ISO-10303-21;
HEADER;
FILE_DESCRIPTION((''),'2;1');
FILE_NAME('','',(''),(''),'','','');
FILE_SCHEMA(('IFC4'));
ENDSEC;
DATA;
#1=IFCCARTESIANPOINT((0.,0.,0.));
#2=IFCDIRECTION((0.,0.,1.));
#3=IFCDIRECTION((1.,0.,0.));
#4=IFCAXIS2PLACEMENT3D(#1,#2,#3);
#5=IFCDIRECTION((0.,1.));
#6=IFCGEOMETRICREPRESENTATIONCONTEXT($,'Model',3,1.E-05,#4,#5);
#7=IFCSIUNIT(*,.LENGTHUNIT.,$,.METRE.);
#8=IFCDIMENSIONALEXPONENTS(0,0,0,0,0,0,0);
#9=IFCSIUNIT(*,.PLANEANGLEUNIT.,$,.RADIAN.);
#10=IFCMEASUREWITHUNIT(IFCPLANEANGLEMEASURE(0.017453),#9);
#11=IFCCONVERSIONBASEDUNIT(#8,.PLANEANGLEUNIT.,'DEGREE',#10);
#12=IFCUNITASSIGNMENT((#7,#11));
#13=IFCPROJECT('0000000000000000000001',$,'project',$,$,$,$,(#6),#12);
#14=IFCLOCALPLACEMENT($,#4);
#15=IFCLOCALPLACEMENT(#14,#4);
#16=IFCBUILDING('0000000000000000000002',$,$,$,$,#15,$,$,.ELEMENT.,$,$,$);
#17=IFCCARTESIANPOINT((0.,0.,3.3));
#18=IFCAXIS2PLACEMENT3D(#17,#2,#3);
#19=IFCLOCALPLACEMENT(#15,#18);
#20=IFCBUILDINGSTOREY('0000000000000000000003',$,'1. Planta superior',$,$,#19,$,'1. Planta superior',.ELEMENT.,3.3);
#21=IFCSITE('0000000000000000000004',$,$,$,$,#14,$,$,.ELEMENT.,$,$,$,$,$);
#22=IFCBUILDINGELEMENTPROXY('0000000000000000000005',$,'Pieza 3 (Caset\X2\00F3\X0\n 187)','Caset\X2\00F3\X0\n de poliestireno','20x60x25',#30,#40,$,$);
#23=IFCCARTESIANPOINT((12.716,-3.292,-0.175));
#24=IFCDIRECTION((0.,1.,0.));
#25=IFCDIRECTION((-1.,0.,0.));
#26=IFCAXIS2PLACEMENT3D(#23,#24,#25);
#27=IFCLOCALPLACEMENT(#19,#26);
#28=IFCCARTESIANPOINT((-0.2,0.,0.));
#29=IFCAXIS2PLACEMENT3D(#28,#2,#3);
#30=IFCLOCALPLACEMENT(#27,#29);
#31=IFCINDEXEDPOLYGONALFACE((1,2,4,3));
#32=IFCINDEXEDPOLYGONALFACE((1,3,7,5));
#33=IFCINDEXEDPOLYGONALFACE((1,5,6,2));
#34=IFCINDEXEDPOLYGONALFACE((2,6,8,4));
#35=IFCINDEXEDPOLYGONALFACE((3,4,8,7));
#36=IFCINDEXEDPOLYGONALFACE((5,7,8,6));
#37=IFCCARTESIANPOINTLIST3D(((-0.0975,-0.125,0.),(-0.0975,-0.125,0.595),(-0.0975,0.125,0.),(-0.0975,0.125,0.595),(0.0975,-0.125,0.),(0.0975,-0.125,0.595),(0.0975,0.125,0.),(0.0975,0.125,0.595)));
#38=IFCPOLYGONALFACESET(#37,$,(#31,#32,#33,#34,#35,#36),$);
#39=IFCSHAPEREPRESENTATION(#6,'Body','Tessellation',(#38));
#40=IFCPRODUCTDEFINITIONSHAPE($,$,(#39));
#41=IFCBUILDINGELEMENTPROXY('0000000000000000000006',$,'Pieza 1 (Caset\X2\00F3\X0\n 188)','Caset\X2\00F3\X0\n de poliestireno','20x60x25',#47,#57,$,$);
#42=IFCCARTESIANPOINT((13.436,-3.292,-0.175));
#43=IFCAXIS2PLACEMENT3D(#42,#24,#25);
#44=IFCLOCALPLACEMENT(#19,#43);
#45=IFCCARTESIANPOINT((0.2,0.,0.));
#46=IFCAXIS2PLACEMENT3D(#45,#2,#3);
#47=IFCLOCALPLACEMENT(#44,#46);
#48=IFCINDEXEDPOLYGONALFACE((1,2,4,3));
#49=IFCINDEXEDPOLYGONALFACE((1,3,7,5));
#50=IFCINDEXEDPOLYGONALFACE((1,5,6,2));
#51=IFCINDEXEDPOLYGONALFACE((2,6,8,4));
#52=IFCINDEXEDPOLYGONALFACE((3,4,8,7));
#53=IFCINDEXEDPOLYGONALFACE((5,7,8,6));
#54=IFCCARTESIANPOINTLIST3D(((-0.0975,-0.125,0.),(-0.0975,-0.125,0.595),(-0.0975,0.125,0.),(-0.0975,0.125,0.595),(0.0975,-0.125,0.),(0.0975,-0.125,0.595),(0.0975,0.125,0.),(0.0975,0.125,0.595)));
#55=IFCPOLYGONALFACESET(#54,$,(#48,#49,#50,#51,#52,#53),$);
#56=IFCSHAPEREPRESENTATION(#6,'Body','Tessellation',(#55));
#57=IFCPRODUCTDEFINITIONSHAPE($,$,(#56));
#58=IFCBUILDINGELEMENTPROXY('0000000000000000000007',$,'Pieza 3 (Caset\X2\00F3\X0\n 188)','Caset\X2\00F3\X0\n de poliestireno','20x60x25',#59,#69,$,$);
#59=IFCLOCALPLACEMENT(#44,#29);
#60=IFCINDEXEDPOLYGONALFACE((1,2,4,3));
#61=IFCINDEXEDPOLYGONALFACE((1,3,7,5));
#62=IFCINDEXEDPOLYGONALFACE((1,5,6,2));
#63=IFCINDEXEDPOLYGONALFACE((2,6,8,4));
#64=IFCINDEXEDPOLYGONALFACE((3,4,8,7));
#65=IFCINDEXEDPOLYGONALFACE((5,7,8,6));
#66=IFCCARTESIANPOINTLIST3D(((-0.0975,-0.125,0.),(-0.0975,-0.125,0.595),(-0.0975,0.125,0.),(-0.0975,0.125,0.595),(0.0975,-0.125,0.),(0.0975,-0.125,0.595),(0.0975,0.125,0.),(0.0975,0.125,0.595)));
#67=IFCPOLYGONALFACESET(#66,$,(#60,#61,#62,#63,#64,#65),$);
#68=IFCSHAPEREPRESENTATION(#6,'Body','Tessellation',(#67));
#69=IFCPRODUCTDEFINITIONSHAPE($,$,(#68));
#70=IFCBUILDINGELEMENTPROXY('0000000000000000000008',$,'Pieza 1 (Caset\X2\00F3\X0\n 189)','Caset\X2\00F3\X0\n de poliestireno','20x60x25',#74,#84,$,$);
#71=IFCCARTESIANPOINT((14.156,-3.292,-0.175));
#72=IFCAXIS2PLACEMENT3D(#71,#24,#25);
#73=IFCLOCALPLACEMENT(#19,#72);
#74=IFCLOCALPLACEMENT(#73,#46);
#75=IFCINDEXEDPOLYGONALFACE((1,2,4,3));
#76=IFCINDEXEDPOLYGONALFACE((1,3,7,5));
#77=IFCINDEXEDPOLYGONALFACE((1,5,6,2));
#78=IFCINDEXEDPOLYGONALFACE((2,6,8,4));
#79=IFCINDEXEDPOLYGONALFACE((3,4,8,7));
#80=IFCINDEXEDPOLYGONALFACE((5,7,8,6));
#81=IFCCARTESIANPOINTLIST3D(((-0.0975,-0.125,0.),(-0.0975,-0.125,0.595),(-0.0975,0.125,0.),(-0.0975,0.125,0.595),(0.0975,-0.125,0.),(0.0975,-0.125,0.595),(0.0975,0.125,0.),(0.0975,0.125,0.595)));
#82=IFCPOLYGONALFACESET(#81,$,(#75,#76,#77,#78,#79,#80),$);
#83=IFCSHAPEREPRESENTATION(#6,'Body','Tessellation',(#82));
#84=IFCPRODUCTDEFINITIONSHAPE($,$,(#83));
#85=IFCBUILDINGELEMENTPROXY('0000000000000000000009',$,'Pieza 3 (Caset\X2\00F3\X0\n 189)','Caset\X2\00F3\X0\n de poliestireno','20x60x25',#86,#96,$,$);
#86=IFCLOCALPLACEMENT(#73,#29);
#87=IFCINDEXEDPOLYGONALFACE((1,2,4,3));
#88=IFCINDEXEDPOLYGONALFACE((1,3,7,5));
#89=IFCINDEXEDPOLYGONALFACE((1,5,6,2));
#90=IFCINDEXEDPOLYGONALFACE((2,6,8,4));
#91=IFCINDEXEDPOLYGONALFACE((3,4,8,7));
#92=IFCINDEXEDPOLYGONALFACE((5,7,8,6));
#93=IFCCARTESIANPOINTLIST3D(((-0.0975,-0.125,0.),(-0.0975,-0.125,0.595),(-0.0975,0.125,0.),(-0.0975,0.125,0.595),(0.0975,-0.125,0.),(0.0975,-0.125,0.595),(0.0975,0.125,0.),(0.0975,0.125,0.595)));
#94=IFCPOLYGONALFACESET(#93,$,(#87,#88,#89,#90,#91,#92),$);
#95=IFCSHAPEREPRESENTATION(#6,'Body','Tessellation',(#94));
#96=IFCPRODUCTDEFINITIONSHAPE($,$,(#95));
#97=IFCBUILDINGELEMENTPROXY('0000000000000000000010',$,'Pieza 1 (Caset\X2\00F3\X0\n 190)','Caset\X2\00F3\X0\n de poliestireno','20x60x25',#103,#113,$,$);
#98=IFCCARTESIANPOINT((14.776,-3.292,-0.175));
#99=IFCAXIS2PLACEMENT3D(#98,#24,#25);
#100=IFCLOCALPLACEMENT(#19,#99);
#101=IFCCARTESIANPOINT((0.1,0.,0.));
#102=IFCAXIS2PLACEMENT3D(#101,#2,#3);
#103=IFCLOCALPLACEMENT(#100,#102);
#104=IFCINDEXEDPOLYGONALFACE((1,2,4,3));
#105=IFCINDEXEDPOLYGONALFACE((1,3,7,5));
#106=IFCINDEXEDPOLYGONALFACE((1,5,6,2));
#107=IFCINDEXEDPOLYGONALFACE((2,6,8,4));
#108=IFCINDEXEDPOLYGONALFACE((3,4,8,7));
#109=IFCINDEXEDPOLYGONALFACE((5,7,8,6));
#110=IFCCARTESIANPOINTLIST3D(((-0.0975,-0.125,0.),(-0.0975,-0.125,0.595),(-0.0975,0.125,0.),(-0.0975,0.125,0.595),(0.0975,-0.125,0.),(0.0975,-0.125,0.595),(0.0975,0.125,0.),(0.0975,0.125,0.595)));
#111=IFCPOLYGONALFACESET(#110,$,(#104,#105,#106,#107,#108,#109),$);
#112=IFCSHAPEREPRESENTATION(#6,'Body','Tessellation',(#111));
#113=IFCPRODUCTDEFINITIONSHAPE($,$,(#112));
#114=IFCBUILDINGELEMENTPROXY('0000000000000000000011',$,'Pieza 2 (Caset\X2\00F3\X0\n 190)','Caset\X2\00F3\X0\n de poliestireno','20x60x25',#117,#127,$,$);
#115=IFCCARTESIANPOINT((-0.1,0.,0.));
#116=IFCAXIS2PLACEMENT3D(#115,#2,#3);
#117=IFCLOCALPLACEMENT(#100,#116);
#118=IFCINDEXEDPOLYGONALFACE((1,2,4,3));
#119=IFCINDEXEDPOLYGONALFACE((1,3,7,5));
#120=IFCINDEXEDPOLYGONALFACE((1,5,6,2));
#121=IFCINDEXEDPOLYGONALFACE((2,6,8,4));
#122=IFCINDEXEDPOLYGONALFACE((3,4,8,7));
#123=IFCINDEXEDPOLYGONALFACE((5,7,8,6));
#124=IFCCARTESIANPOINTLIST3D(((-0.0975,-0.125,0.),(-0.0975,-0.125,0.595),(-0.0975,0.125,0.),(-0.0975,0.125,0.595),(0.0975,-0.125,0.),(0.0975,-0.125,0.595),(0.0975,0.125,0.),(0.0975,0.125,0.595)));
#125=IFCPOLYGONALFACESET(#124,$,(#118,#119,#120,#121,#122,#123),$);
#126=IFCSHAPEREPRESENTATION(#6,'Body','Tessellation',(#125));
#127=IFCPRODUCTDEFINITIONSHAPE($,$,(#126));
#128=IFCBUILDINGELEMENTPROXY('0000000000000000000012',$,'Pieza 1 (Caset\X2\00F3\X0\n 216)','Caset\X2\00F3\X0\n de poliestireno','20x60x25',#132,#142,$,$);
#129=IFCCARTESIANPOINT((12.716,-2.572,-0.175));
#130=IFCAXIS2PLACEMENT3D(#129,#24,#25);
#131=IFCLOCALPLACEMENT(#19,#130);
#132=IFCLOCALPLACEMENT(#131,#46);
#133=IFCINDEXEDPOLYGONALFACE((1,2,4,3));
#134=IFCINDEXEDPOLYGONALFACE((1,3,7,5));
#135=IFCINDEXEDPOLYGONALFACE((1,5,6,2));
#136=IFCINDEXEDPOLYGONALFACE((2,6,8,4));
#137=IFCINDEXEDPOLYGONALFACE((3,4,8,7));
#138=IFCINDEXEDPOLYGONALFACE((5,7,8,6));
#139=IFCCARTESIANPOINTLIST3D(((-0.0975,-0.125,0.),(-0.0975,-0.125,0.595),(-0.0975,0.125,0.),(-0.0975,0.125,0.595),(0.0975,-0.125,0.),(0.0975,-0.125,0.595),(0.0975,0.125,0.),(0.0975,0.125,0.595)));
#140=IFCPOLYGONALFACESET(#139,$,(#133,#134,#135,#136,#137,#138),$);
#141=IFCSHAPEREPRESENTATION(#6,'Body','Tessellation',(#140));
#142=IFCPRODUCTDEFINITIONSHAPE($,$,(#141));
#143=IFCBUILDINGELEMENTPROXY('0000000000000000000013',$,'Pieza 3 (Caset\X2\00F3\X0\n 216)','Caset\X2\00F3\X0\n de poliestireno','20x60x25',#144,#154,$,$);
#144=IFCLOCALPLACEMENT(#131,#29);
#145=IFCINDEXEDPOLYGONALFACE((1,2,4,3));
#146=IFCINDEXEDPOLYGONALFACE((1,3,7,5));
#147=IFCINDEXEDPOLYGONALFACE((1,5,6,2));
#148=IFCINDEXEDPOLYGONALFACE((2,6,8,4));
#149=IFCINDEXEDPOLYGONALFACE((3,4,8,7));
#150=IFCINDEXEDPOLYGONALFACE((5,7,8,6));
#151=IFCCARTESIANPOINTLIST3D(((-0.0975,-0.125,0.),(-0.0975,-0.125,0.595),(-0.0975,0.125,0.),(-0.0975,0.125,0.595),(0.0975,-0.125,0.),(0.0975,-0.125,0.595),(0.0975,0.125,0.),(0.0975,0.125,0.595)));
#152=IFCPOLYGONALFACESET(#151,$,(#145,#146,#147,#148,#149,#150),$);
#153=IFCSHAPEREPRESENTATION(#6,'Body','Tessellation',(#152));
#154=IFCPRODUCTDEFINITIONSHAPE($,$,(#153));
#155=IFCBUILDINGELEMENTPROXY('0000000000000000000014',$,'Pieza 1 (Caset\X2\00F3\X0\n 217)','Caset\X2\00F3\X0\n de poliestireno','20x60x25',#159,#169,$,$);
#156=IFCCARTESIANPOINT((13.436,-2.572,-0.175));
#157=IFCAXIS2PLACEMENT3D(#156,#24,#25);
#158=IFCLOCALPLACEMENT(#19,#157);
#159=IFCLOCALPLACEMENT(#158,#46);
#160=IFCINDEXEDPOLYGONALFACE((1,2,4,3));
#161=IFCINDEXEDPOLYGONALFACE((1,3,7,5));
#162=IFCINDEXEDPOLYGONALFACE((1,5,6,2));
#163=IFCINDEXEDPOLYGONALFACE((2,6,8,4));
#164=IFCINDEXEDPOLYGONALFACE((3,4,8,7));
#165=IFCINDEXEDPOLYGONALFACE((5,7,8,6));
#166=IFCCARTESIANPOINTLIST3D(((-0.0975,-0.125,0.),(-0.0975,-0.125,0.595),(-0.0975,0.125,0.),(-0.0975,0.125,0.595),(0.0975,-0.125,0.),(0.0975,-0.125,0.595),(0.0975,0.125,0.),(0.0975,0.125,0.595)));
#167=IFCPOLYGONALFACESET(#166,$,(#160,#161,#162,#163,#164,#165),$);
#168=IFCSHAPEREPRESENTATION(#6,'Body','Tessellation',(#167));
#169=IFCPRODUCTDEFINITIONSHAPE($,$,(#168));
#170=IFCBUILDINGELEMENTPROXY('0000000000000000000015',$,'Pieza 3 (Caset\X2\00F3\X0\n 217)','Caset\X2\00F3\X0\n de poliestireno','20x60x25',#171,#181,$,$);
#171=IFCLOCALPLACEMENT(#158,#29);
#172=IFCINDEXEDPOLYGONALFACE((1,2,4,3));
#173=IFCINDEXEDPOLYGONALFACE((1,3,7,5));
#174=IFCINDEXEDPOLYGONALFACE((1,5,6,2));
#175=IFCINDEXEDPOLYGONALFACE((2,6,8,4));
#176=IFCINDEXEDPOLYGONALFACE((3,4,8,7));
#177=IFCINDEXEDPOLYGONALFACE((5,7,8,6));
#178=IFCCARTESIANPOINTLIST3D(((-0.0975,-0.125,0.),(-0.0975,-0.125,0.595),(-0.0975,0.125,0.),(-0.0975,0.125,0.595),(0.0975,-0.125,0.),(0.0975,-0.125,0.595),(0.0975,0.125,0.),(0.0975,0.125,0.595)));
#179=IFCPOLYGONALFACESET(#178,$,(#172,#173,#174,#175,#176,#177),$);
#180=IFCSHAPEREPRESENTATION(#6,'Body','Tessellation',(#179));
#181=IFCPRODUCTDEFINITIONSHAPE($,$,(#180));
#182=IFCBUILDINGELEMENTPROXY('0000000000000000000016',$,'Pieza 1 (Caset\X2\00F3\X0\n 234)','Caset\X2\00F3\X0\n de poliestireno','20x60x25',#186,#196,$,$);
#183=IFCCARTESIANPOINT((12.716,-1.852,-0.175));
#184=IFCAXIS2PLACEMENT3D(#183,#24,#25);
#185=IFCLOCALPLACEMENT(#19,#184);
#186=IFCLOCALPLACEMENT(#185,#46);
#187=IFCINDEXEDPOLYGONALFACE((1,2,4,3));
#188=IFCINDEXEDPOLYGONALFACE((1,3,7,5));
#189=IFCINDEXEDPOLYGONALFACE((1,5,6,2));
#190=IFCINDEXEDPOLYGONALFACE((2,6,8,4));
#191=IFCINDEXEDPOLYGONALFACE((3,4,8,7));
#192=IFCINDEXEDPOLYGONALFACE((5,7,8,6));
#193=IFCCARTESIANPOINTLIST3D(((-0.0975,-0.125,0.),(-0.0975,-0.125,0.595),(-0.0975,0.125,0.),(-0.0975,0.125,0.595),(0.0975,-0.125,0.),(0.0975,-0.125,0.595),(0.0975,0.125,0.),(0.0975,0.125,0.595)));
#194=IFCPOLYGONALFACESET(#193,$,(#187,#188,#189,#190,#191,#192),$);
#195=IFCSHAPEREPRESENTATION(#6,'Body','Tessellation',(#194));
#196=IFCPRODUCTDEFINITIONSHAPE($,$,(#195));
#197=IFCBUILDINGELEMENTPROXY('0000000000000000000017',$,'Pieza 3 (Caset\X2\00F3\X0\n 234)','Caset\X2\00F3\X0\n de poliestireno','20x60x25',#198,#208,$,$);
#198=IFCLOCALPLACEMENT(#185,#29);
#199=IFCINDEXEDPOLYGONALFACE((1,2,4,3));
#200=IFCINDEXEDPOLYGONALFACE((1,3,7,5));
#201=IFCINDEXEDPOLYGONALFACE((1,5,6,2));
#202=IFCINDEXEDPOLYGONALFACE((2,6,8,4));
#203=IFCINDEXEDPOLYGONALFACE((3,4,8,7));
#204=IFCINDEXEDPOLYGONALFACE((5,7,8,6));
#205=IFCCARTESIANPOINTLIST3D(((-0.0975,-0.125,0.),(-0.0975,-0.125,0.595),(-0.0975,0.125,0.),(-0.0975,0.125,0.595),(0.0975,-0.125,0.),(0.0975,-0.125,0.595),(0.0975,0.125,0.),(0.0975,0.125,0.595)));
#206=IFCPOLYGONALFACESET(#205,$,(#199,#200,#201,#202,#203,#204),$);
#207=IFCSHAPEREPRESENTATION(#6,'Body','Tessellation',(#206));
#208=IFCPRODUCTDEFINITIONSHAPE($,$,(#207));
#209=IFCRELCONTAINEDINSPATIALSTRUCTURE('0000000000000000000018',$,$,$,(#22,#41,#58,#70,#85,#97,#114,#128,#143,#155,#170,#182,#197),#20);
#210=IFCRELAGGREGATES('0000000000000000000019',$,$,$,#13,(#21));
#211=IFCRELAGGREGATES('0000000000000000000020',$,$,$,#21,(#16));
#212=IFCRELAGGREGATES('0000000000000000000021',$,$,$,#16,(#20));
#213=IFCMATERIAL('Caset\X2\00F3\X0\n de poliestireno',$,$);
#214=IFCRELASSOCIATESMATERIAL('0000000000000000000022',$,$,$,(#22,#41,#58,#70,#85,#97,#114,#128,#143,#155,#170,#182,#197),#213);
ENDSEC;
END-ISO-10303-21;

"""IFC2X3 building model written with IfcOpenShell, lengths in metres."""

from ifc_helpers import new_model, entity, si_unit, converted_unit, direction, frame, origin_with_axes, origin_2d_with_axis, place, context, project, spatial, rectangle, extrude, source, transform, mapped, material, element, save


model = new_model("IFC2X3")

# Units and contexts
model_context = context("Model", 3, precision=1e-05, world=origin_with_axes(), true_north=direction((0.0, 1.0)))
ifc_project = project(units=[si_unit("LENGTHUNIT", "METRE"), converted_unit("PLANEANGLEUNIT", "DEGREE", entity("IfcPlaneAngleMeasure", 0.017453), si_unit("PLANEANGLEUNIT", "RADIAN"), dimensions=[0, 0, 0, 0, 0, 0, 0])], contexts=[model_context])

# Site, building, storey
site_placement = place(None, origin_with_axes())
site = spatial("IfcSite", under=ifc_project, at=site_placement, CompositionType="ELEMENT")
building_placement = place(site_placement, origin_with_axes())
building = spatial("IfcBuilding", under=site, at=building_placement, CompositionType="ELEMENT")
storey_placement = place(building_placement, frame((0.0, 0.0, 3.3), z_axis=(0.0, 0.0, 1.0), x_axis=(1.0, 0.0, 0.0)))
storey = spatial("IfcBuildingStorey", under=building, at=storey_placement, Name="1. Planta superior", LongName="1. Planta superior", CompositionType="ELEMENT", Elevation=3.3)

# Building element proxies
ifc_material = material(Name="Casetón de poliestireno")
shared_shape = source(origin_with_axes(), model_context, "Body", "SweptSolid", [
    extrude(rectangle(XDim=0.195, YDim=0.25, at=origin_2d_with_axis()), origin_with_axes(), (0.0, 0.0, 1.0), 0.595),
])
placement_1 = place(storey_placement, frame((12.716, -3.292, -0.175), z_axis=(0.0, 1.0, 0.0), x_axis=(-1.0, 0.0, 0.0)))
for number, where, z_axis, x_axis, name in (
    (1, (-0.2, 0.0, 0.0), (0.0, 0.0, 1.0), (1.0, 0.0, 0.0), "Pieza 3 (Casetón 187)"),
):
    element("IfcBuildingElementProxy", number, at=place(placement_1, frame(where, z_axis=z_axis, x_axis=x_axis)), inside=storey, material=ifc_material, Name=name, Description="Casetón de poliestireno", ObjectType="20x60x25", context=model_context, shape_type="MappedRepresentation", body=[
        mapped(shared_shape, transform((0.0, 0.0, 0.0), x_axis=(1.0, 0.0, 0.0), y_axis=(0.0, 1.0, 0.0), z_axis=(0.0, 0.0, 1.0))),
    ])
placement_2 = place(storey_placement, frame((13.436, -3.292, -0.175), z_axis=(0.0, 1.0, 0.0), x_axis=(-1.0, 0.0, 0.0)))
for number, where, z_axis, x_axis, name in (
    (2, (0.2, 0.0, 0.0), (0.0, 0.0, 1.0), (1.0, 0.0, 0.0), "Pieza 1 (Casetón 188)"),
    (3, (-0.2, 0.0, 0.0), (0.0, 0.0, 1.0), (1.0, 0.0, 0.0), "Pieza 3 (Casetón 188)"),
):
    element("IfcBuildingElementProxy", number, at=place(placement_2, frame(where, z_axis=z_axis, x_axis=x_axis)), inside=storey, material=ifc_material, Name=name, Description="Casetón de poliestireno", ObjectType="20x60x25", context=model_context, shape_type="MappedRepresentation", body=[
        mapped(shared_shape, transform((0.0, 0.0, 0.0), x_axis=(1.0, 0.0, 0.0), y_axis=(0.0, 1.0, 0.0), z_axis=(0.0, 0.0, 1.0))),
    ])
placement_3 = place(storey_placement, frame((14.156, -3.292, -0.175), z_axis=(0.0, 1.0, 0.0), x_axis=(-1.0, 0.0, 0.0)))
for number, where, z_axis, x_axis, name in (
    (4, (0.2, 0.0, 0.0), (0.0, 0.0, 1.0), (1.0, 0.0, 0.0), "Pieza 1 (Casetón 189)"),
    (5, (-0.2, 0.0, 0.0), (0.0, 0.0, 1.0), (1.0, 0.0, 0.0), "Pieza 3 (Casetón 189)"),
):
    element("IfcBuildingElementProxy", number, at=place(placement_3, frame(where, z_axis=z_axis, x_axis=x_axis)), inside=storey, material=ifc_material, Name=name, Description="Casetón de poliestireno", ObjectType="20x60x25", context=model_context, shape_type="MappedRepresentation", body=[
        mapped(shared_shape, transform((0.0, 0.0, 0.0), x_axis=(1.0, 0.0, 0.0), y_axis=(0.0, 1.0, 0.0), z_axis=(0.0, 0.0, 1.0))),
    ])
placement_4 = place(storey_placement, frame((14.776, -3.292, -0.175), z_axis=(0.0, 1.0, 0.0), x_axis=(-1.0, 0.0, 0.0)))
for number, where, z_axis, x_axis, name in (
    (6, (0.1, 0.0, 0.0), (0.0, 0.0, 1.0), (1.0, 0.0, 0.0), "Pieza 1 (Casetón 190)"),
    (7, (-0.1, 0.0, 0.0), (0.0, 0.0, 1.0), (1.0, 0.0, 0.0), "Pieza 2 (Casetón 190)"),
):
    element("IfcBuildingElementProxy", number, at=place(placement_4, frame(where, z_axis=z_axis, x_axis=x_axis)), inside=storey, material=ifc_material, Name=name, Description="Casetón de poliestireno", ObjectType="20x60x25", context=model_context, shape_type="MappedRepresentation", body=[
        mapped(shared_shape, transform((0.0, 0.0, 0.0), x_axis=(1.0, 0.0, 0.0), y_axis=(0.0, 1.0, 0.0), z_axis=(0.0, 0.0, 1.0))),
    ])
placement_5 = place(storey_placement, frame((12.716, -2.572, -0.175), z_axis=(0.0, 1.0, 0.0), x_axis=(-1.0, 0.0, 0.0)))
for number, where, z_axis, x_axis, name in (
    (8, (0.2, 0.0, 0.0), (0.0, 0.0, 1.0), (1.0, 0.0, 0.0), "Pieza 1 (Casetón 216)"),
    (9, (-0.2, 0.0, 0.0), (0.0, 0.0, 1.0), (1.0, 0.0, 0.0), "Pieza 3 (Casetón 216)"),
):
    element("IfcBuildingElementProxy", number, at=place(placement_5, frame(where, z_axis=z_axis, x_axis=x_axis)), inside=storey, material=ifc_material, Name=name, Description="Casetón de poliestireno", ObjectType="20x60x25", context=model_context, shape_type="MappedRepresentation", body=[
        mapped(shared_shape, transform((0.0, 0.0, 0.0), x_axis=(1.0, 0.0, 0.0), y_axis=(0.0, 1.0, 0.0), z_axis=(0.0, 0.0, 1.0))),
    ])
placement_6 = place(storey_placement, frame((13.436, -2.572, -0.175), z_axis=(0.0, 1.0, 0.0), x_axis=(-1.0, 0.0, 0.0)))
for number, where, z_axis, x_axis, name in (
    (10, (0.2, 0.0, 0.0), (0.0, 0.0, 1.0), (1.0, 0.0, 0.0), "Pieza 1 (Casetón 217)"),
    (11, (-0.2, 0.0, 0.0), (0.0, 0.0, 1.0), (1.0, 0.0, 0.0), "Pieza 3 (Casetón 217)"),
):
    element("IfcBuildingElementProxy", number, at=place(placement_6, frame(where, z_axis=z_axis, x_axis=x_axis)), inside=storey, material=ifc_material, Name=name, Description="Casetón de poliestireno", ObjectType="20x60x25", context=model_context, shape_type="MappedRepresentation", body=[
        mapped(shared_shape, transform((0.0, 0.0, 0.0), x_axis=(1.0, 0.0, 0.0), y_axis=(0.0, 1.0, 0.0), z_axis=(0.0, 0.0, 1.0))),
    ])
placement_7 = place(storey_placement, frame((12.716, -1.852, -0.175), z_axis=(0.0, 1.0, 0.0), x_axis=(-1.0, 0.0, 0.0)))
for number, where, z_axis, x_axis, name in (
    (12, (0.2, 0.0, 0.0), (0.0, 0.0, 1.0), (1.0, 0.0, 0.0), "Pieza 1 (Casetón 234)"),
    (13, (-0.2, 0.0, 0.0), (0.0, 0.0, 1.0), (1.0, 0.0, 0.0), "Pieza 3 (Casetón 234)"),
):
    element("IfcBuildingElementProxy", number, at=place(placement_7, frame(where, z_axis=z_axis, x_axis=x_axis)), inside=storey, material=ifc_material, Name=name, Description="Casetón de poliestireno", ObjectType="20x60x25", context=model_context, shape_type="MappedRepresentation", body=[
        mapped(shared_shape, transform((0.0, 0.0, 0.0), x_axis=(1.0, 0.0, 0.0), y_axis=(0.0, 1.0, 0.0), z_axis=(0.0, 0.0, 1.0))),
    ])

save(model, "model.ifc")
